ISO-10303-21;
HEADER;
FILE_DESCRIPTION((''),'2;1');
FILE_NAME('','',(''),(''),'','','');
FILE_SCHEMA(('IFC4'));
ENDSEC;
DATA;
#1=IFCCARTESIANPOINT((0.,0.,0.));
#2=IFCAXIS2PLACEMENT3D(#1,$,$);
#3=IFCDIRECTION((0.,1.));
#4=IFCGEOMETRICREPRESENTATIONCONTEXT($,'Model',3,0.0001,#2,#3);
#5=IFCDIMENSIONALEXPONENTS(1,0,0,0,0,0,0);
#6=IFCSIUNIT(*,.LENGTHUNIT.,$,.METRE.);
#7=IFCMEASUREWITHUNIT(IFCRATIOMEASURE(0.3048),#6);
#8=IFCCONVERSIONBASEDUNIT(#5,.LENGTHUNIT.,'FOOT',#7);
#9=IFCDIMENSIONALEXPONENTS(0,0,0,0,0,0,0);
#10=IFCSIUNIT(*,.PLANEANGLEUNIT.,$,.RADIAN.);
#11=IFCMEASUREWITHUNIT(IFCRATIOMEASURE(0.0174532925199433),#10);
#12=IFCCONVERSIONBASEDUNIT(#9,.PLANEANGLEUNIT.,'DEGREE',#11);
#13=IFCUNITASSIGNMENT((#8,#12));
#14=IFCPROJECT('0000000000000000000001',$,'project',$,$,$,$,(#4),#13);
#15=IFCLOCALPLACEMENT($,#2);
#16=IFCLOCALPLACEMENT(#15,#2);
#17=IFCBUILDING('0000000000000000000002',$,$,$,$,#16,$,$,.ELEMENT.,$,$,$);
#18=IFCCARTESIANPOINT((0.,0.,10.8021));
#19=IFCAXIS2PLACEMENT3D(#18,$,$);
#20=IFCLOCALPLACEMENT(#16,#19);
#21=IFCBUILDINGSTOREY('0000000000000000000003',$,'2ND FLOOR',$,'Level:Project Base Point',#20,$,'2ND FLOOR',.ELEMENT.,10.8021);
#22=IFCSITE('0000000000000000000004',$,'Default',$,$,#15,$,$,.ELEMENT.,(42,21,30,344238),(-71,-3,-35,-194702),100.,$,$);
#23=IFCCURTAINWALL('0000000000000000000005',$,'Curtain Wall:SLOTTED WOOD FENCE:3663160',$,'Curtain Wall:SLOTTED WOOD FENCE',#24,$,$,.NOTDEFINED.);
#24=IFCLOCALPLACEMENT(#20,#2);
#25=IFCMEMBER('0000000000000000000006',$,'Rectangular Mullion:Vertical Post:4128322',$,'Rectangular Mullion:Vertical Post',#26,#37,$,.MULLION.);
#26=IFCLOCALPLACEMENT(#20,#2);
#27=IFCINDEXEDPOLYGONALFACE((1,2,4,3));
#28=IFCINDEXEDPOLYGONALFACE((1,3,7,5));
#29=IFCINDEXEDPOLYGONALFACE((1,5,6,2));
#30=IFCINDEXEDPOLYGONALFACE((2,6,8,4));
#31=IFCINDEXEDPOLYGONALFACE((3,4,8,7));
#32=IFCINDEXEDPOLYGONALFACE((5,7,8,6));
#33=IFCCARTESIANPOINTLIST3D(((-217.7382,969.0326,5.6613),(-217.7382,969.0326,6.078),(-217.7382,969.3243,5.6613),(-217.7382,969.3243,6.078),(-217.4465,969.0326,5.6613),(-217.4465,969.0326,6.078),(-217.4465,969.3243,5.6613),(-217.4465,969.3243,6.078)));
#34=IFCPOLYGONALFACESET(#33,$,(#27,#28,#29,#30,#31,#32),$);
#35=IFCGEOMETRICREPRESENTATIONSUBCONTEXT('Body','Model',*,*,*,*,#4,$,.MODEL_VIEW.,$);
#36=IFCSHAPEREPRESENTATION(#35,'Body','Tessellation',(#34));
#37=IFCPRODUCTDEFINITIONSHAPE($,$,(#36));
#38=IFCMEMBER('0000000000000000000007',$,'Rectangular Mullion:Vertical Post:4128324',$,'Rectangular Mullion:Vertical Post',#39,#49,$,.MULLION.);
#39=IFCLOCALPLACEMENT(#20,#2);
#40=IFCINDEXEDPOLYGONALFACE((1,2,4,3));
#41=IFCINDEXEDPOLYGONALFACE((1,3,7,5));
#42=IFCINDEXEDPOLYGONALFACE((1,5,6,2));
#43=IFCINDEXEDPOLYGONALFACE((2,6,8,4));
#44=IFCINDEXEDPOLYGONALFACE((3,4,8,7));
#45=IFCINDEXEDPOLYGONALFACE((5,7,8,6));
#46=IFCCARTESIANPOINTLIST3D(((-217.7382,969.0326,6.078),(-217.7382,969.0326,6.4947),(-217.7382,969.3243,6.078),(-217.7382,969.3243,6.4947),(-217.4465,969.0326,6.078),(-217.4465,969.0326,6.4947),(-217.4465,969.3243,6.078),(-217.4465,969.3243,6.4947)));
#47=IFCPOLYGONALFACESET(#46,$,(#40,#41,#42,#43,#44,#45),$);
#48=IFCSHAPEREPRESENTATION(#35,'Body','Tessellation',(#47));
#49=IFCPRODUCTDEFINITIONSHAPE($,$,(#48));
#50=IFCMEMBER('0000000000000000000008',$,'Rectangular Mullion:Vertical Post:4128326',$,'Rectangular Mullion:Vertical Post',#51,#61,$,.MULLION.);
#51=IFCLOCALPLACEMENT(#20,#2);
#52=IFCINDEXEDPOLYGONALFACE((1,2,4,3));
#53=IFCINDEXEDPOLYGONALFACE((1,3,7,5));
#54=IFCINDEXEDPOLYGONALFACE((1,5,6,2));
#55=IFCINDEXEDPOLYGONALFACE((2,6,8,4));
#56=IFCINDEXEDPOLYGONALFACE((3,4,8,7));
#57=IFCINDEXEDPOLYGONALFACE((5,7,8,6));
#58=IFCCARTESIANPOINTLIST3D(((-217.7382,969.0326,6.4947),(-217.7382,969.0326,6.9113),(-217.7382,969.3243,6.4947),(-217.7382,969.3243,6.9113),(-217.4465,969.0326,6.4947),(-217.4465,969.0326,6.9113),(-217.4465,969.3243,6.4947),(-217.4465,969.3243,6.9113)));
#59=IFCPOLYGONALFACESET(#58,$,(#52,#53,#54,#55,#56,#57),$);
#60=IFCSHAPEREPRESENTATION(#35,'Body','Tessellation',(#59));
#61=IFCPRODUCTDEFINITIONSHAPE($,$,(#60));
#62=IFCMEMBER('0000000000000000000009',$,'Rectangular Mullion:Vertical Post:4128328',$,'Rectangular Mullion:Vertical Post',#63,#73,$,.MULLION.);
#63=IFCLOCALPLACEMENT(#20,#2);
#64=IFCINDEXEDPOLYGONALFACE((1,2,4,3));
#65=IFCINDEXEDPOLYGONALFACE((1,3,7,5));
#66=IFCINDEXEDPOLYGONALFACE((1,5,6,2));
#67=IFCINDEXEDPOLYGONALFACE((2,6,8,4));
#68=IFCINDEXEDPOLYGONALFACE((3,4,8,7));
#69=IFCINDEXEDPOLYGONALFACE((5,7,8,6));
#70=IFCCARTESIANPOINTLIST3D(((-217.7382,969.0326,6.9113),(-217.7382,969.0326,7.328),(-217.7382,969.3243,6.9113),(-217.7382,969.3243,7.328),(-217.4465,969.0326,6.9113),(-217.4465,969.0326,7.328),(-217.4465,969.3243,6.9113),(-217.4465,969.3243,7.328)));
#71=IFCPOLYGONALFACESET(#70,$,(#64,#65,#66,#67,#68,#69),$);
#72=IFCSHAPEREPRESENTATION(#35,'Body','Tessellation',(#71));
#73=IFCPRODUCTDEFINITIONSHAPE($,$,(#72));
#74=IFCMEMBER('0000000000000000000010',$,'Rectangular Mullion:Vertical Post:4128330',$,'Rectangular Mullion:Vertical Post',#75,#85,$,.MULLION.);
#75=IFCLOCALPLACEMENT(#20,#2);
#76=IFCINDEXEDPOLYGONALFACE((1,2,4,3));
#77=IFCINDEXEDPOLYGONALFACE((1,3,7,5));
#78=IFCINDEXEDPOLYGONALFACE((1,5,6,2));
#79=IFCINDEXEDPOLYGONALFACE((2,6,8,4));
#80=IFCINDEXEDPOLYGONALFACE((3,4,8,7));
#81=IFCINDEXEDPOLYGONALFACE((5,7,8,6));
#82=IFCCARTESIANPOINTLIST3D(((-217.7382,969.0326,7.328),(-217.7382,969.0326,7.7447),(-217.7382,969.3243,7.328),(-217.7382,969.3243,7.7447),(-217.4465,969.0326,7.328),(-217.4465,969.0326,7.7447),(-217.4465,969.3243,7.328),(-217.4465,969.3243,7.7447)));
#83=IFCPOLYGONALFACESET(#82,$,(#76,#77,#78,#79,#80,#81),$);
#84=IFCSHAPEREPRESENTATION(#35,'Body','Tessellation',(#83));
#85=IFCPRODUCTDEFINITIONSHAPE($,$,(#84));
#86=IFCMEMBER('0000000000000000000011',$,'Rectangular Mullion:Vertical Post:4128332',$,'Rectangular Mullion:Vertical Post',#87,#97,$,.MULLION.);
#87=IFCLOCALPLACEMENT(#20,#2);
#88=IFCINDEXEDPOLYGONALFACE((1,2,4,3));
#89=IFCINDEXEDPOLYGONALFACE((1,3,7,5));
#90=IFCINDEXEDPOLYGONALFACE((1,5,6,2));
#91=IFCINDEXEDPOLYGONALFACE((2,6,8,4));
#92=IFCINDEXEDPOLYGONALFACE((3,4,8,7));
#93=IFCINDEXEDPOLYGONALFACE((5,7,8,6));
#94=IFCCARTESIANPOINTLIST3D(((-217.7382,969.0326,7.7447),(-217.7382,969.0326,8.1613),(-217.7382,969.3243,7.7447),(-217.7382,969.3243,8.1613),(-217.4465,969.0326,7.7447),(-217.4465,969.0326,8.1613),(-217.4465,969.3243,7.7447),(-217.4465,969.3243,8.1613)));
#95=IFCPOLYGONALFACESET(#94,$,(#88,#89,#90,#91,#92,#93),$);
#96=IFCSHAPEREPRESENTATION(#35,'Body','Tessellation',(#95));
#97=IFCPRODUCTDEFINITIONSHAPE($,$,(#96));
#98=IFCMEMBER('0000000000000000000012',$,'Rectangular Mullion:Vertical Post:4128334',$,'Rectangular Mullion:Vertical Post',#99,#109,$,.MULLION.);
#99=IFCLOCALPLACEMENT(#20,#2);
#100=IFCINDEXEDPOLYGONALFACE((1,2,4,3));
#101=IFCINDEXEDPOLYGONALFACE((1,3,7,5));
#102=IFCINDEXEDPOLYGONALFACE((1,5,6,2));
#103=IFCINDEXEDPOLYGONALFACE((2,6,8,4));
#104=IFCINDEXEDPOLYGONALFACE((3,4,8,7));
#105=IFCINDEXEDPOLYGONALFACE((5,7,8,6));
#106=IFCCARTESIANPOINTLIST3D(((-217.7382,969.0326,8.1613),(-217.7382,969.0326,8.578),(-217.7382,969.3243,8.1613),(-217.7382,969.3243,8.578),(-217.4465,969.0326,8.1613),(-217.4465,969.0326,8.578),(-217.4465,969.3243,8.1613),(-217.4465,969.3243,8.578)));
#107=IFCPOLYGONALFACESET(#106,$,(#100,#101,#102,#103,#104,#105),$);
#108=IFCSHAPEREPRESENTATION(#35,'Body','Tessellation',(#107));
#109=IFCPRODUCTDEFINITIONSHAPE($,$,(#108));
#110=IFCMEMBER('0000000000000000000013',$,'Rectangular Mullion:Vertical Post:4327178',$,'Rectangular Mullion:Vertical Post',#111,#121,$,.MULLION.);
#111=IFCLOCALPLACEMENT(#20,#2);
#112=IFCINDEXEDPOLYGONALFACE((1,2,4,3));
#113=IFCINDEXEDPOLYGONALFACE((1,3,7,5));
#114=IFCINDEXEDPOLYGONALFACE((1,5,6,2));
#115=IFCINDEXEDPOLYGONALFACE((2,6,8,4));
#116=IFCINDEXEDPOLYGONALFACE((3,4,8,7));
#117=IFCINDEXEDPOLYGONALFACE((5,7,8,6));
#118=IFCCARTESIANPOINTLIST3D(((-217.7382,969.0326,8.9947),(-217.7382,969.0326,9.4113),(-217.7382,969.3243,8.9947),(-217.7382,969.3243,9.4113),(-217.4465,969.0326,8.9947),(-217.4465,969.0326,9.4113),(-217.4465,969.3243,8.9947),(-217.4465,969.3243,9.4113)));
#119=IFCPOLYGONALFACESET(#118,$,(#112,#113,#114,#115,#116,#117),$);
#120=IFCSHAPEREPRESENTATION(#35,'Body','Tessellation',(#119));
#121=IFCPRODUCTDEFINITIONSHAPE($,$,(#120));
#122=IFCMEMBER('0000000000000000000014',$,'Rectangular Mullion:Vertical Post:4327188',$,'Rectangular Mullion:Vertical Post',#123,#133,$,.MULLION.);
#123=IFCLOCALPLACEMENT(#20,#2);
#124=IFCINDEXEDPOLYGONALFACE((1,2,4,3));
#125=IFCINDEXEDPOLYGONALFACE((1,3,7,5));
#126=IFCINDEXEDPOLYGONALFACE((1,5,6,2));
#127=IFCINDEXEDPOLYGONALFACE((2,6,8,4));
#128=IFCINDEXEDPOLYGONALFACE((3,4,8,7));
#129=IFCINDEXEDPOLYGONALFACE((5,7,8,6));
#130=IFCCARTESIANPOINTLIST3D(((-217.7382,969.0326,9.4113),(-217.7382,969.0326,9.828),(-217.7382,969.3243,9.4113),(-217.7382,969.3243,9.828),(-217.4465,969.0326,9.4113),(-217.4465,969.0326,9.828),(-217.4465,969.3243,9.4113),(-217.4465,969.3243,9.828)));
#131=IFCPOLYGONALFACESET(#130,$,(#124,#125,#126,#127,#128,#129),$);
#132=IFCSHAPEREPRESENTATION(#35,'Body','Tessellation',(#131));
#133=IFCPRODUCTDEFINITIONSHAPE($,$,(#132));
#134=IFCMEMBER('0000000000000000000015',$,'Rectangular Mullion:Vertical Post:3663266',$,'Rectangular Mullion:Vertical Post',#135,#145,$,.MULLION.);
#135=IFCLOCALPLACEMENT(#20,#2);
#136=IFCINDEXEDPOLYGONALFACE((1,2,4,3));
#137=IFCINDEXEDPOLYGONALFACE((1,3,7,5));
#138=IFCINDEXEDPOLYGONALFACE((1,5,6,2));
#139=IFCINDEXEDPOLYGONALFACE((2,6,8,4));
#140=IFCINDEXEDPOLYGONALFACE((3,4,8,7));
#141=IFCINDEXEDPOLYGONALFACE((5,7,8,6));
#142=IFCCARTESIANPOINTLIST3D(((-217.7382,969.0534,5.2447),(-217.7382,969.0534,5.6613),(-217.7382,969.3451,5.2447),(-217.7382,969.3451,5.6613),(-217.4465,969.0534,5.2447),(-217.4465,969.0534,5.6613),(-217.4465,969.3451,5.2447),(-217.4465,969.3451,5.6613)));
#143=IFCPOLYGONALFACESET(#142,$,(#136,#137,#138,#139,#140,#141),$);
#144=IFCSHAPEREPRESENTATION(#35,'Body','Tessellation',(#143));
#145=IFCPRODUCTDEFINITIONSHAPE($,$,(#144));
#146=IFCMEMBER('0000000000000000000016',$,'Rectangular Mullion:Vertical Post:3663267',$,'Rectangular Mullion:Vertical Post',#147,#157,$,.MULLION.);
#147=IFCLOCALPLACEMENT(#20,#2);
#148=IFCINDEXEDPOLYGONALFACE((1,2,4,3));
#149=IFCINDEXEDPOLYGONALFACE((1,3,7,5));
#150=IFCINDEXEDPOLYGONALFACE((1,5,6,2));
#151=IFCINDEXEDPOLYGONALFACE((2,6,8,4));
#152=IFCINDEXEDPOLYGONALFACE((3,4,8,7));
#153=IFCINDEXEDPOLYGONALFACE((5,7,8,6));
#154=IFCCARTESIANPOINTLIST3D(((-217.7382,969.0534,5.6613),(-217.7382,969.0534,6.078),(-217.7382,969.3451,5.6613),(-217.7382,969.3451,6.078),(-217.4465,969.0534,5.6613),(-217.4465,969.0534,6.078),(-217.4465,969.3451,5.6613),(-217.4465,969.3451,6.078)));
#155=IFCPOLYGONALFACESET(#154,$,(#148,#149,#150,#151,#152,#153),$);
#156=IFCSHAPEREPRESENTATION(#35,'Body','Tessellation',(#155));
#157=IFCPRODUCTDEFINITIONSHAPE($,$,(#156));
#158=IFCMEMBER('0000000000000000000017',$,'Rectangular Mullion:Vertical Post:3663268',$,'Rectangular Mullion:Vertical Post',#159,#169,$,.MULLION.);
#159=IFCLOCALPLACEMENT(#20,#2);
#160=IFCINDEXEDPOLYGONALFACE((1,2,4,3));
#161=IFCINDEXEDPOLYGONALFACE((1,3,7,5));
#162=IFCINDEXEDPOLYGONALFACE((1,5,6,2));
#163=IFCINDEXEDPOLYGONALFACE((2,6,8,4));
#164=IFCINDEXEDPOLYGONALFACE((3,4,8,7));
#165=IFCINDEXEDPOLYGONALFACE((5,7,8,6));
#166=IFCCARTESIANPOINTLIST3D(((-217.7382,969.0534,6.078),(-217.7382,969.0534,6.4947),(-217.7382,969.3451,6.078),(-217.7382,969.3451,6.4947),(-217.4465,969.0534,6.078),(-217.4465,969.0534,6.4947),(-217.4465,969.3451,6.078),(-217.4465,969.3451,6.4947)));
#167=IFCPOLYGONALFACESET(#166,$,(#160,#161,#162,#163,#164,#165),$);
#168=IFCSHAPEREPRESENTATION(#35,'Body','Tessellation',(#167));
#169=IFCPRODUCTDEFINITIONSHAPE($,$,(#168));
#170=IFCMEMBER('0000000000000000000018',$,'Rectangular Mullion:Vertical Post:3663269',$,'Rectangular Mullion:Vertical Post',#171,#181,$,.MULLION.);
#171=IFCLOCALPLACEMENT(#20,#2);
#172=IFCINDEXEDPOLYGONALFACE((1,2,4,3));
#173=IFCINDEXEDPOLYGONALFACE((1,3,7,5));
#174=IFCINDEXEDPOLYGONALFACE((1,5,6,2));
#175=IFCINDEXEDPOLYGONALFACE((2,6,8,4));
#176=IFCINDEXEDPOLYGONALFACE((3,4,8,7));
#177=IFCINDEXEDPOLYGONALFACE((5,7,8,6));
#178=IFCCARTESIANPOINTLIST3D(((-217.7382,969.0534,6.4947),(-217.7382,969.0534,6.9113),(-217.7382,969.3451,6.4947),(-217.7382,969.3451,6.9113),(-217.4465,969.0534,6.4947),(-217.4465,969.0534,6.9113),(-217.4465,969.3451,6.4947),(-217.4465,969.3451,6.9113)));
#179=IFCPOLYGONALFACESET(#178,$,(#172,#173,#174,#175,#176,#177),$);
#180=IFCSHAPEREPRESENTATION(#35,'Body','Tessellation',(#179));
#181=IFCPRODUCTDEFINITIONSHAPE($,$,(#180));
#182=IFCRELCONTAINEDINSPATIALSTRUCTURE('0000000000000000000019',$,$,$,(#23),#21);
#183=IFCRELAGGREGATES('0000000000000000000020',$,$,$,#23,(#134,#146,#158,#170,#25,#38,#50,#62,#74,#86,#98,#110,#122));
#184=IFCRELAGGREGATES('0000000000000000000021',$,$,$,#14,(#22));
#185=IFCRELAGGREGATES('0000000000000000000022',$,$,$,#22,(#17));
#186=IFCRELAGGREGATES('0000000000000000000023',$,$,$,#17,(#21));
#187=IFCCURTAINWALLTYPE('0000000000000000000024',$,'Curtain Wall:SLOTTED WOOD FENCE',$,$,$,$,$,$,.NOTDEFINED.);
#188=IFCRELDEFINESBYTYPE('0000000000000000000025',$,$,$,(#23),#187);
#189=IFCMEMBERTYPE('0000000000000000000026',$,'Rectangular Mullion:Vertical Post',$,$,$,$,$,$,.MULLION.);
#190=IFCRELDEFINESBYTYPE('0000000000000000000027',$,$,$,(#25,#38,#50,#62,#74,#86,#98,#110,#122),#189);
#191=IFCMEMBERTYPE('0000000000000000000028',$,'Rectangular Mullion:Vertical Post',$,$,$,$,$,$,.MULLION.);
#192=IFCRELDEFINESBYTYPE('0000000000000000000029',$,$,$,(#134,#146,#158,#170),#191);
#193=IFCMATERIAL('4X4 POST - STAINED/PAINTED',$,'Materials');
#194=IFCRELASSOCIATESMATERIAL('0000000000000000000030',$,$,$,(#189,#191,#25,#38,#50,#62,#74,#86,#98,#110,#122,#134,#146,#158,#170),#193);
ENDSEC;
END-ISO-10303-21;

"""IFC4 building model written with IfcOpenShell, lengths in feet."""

from ifc_helpers import new_model, entity, si_unit, converted_unit, direction, frame, origin, origin_2d_with_axis, place, context, subcontext, project, spatial, rectangle, extrude, source, transform, mapped, material, material_profile, profile_set, profile_usage, type_object, type_shapes, element, aggregate, save


model = new_model("IFC4")

# Units and contexts
model_context = context("Model", 3, precision=0.0001, world=origin(), true_north=direction((0.0, 1.0)))
body_context = subcontext(model_context, "Body", "Model", "MODEL_VIEW")
ifc_project = project(units=[converted_unit("LENGTHUNIT", "FOOT", entity("IfcRatioMeasure", 0.3048), si_unit("LENGTHUNIT", "METRE"), dimensions=[1, 0, 0, 0, 0, 0, 0]), converted_unit("PLANEANGLEUNIT", "DEGREE", entity("IfcRatioMeasure", 0.0174532925199433), si_unit("PLANEANGLEUNIT", "RADIAN"), dimensions=[0, 0, 0, 0, 0, 0, 0])], contexts=[model_context])

# Site, building, storey
site_placement = place(None, origin())
site = spatial("IfcSite", under=ifc_project, at=site_placement, Name="Default", CompositionType="ELEMENT", RefLatitude=(42, 21, 30, 344238), RefLongitude=(-71, -3, -35, -194702), RefElevation=100.0)
building_placement = place(site_placement, origin())
building = spatial("IfcBuilding", under=site, at=building_placement, CompositionType="ELEMENT")
storey_placement = place(building_placement, frame((0.0, 0.0, 10.8021)))
storey = spatial("IfcBuildingStorey", under=building, at=storey_placement, Name="2ND FLOOR", ObjectType="Level:Project Base Point", LongName="2ND FLOOR", CompositionType="ELEMENT", Elevation=10.8021)

# Curtain wall, members
curtain_wall_type = type_object("IfcCurtainWallType", Name="Curtain Wall:SLOTTED WOOD FENCE", PredefinedType="NOTDEFINED")
curtain_wall_placement = place(storey_placement, frame((0.0, 0.0, -10.8021)))
curtain_wall = element("IfcCurtainWall", 1, at=curtain_wall_placement, inside=storey, type_object=curtain_wall_type, Name="Curtain Wall:SLOTTED WOOD FENCE:3663160", ObjectType="Curtain Wall:SLOTTED WOOD FENCE", PredefinedType="NOTDEFINED")
ifc_material_1 = material(Name="4X4 POST - STAINED/PAINTED", Category="Materials")
ifc_material_profile = material_profile(ifc_material_1, rectangle(XDim=0.2917, YDim=0.2917, at=origin_2d_with_axis()), Name="Vertical Post")
ifc_profile_set = profile_set([ifc_material_profile], Name="Vertical Post")
ifc_profile_usage_1 = profile_usage(ifc_profile_set)
member_type_1 = type_object("IfcMemberType", Name="Rectangular Mullion:Vertical Post", PredefinedType="MULLION", material=ifc_profile_set)
shared_shape_1 = source(origin(), body_context, "Body", "SweptSolid", [
    extrude(rectangle(XDim=0.2917, YDim=0.2917, at=origin_2d_with_axis()), frame((0.0, -0.2083, -0.4167), z_axis=(0.0, 0.0, 1.0), x_axis=(0.0, -1.0, 0.0)), (0.0, 0.0, 1.0), 0.4167),
])
type_shapes(member_type_1, [shared_shape_1])
member_1_placement = place(storey_placement, frame((-217.8007, 969.1784, 5.6613), z_axis=(0.0, 0.0, -1.0), x_axis=(0.0, -1.0, 0.0)))
member_1 = element("IfcMember", 2, at=member_1_placement, type_object=member_type_1, material=ifc_profile_usage_1, Name="Rectangular Mullion:Vertical Post:4128322", ObjectType="Rectangular Mullion:Vertical Post", PredefinedType="MULLION", context=body_context, shape_type="MappedRepresentation", body=[
    mapped(shared_shape_1, transform((0.0, 0.0, 0.0), scale=1.0)),
])
ifc_profile_usage_2 = profile_usage(ifc_profile_set)
member_2_placement = place(storey_placement, frame((-217.8007, 969.1784, 6.078), z_axis=(0.0, 0.0, -1.0), x_axis=(0.0, -1.0, 0.0)))
member_2 = element("IfcMember", 3, at=member_2_placement, type_object=member_type_1, material=ifc_profile_usage_2, Name="Rectangular Mullion:Vertical Post:4128324", ObjectType="Rectangular Mullion:Vertical Post", PredefinedType="MULLION", context=body_context, shape_type="MappedRepresentation", body=[
    mapped(shared_shape_1, transform((0.0, 0.0, 0.0), scale=1.0)),
])
ifc_profile_usage_3 = profile_usage(ifc_profile_set)
member_3_placement = place(storey_placement, frame((-217.8007, 969.1784, 6.4947), z_axis=(0.0, 0.0, -1.0), x_axis=(0.0, -1.0, 0.0)))
member_3 = element("IfcMember", 4, at=member_3_placement, type_object=member_type_1, material=ifc_profile_usage_3, Name="Rectangular Mullion:Vertical Post:4128326", ObjectType="Rectangular Mullion:Vertical Post", PredefinedType="MULLION", context=body_context, shape_type="MappedRepresentation", body=[
    mapped(shared_shape_1, transform((0.0, 0.0, 0.0), scale=1.0)),
])
ifc_profile_usage_4 = profile_usage(ifc_profile_set)
member_4_placement = place(storey_placement, frame((-217.8007, 969.1784, 6.9113), z_axis=(0.0, 0.0, -1.0), x_axis=(0.0, -1.0, 0.0)))
member_4 = element("IfcMember", 5, at=member_4_placement, type_object=member_type_1, material=ifc_profile_usage_4, Name="Rectangular Mullion:Vertical Post:4128328", ObjectType="Rectangular Mullion:Vertical Post", PredefinedType="MULLION", context=body_context, shape_type="MappedRepresentation", body=[
    mapped(shared_shape_1, transform((0.0, 0.0, 0.0), scale=1.0)),
])
ifc_profile_usage_5 = profile_usage(ifc_profile_set)
member_5_placement = place(storey_placement, frame((-217.8007, 969.1784, 7.328), z_axis=(0.0, 0.0, -1.0), x_axis=(0.0, -1.0, 0.0)))
member_5 = element("IfcMember", 6, at=member_5_placement, type_object=member_type_1, material=ifc_profile_usage_5, Name="Rectangular Mullion:Vertical Post:4128330", ObjectType="Rectangular Mullion:Vertical Post", PredefinedType="MULLION", context=body_context, shape_type="MappedRepresentation", body=[
    mapped(shared_shape_1, transform((0.0, 0.0, 0.0), scale=1.0)),
])
ifc_profile_usage_6 = profile_usage(ifc_profile_set)
member_6_placement = place(storey_placement, frame((-217.8007, 969.1784, 7.7447), z_axis=(0.0, 0.0, -1.0), x_axis=(0.0, -1.0, 0.0)))
member_6 = element("IfcMember", 7, at=member_6_placement, type_object=member_type_1, material=ifc_profile_usage_6, Name="Rectangular Mullion:Vertical Post:4128332", ObjectType="Rectangular Mullion:Vertical Post", PredefinedType="MULLION", context=body_context, shape_type="MappedRepresentation", body=[
    mapped(shared_shape_1, transform((0.0, 0.0, 0.0), scale=1.0)),
])
ifc_profile_usage_7 = profile_usage(ifc_profile_set)
member_7_placement = place(storey_placement, frame((-217.8007, 969.1784, 8.1613), z_axis=(0.0, 0.0, -1.0), x_axis=(0.0, -1.0, 0.0)))
member_7 = element("IfcMember", 8, at=member_7_placement, type_object=member_type_1, material=ifc_profile_usage_7, Name="Rectangular Mullion:Vertical Post:4128334", ObjectType="Rectangular Mullion:Vertical Post", PredefinedType="MULLION", context=body_context, shape_type="MappedRepresentation", body=[
    mapped(shared_shape_1, transform((0.0, 0.0, 0.0), scale=1.0)),
])
ifc_profile_usage_8 = profile_usage(ifc_profile_set)
member_8_placement = place(storey_placement, frame((-217.8007, 969.1784, 8.9947), z_axis=(0.0, 0.0, -1.0), x_axis=(0.0, -1.0, 0.0)))
member_8 = element("IfcMember", 9, at=member_8_placement, type_object=member_type_1, material=ifc_profile_usage_8, Name="Rectangular Mullion:Vertical Post:4327178", ObjectType="Rectangular Mullion:Vertical Post", PredefinedType="MULLION", context=body_context, shape_type="MappedRepresentation", body=[
    mapped(shared_shape_1, transform((0.0, 0.0, 0.0), scale=1.0)),
])
ifc_profile_usage_9 = profile_usage(ifc_profile_set)
member_9_placement = place(storey_placement, frame((-217.8007, 969.1784, 9.4113), z_axis=(0.0, 0.0, -1.0), x_axis=(0.0, -1.0, 0.0)))
member_9 = element("IfcMember", 10, at=member_9_placement, type_object=member_type_1, material=ifc_profile_usage_9, Name="Rectangular Mullion:Vertical Post:4327188", ObjectType="Rectangular Mullion:Vertical Post", PredefinedType="MULLION", context=body_context, shape_type="MappedRepresentation", body=[
    mapped(shared_shape_1, transform((0.0, 0.0, 0.0), scale=1.0)),
])
ifc_profile_usage_10 = profile_usage(ifc_profile_set)
member_type_2 = type_object("IfcMemberType", Name="Rectangular Mullion:Vertical Post", PredefinedType="MULLION", material=ifc_profile_set)
shared_shape_2 = source(origin(), body_context, "Body", "SweptSolid", [
    extrude(rectangle(XDim=0.2917, YDim=0.2917, at=origin_2d_with_axis()), frame((-0.1458, -0.2083, -0.4167), z_axis=(0.0, 0.0, 1.0), x_axis=(0.0, -1.0, 0.0)), (0.0, 0.0, 1.0), 0.4167),
])
type_shapes(member_type_2, [shared_shape_2])
member_10_placement = place(storey_placement, frame((-217.8007, 969.3451, 5.6613), z_axis=(0.0, 0.0, 1.0), x_axis=(0.0, 1.0, 0.0)))
member_10 = element("IfcMember", 11, at=member_10_placement, type_object=member_type_2, material=ifc_profile_usage_10, Name="Rectangular Mullion:Vertical Post:3663266", ObjectType="Rectangular Mullion:Vertical Post", PredefinedType="MULLION", context=body_context, shape_type="MappedRepresentation", body=[
    mapped(shared_shape_2, transform((0.0, 0.0, 0.0), scale=1.0)),
])
ifc_profile_usage_11 = profile_usage(ifc_profile_set)
member_11_placement = place(storey_placement, frame((-217.8007, 969.3451, 6.078), z_axis=(0.0, 0.0, 1.0), x_axis=(0.0, 1.0, 0.0)))
member_11 = element("IfcMember", 12, at=member_11_placement, type_object=member_type_2, material=ifc_profile_usage_11, Name="Rectangular Mullion:Vertical Post:3663267", ObjectType="Rectangular Mullion:Vertical Post", PredefinedType="MULLION", context=body_context, shape_type="MappedRepresentation", body=[
    mapped(shared_shape_2, transform((0.0, 0.0, 0.0), scale=1.0)),
])
ifc_profile_usage_12 = profile_usage(ifc_profile_set)
member_12_placement = place(storey_placement, frame((-217.8007, 969.3451, 6.4947), z_axis=(0.0, 0.0, 1.0), x_axis=(0.0, 1.0, 0.0)))
member_12 = element("IfcMember", 13, at=member_12_placement, type_object=member_type_2, material=ifc_profile_usage_12, Name="Rectangular Mullion:Vertical Post:3663268", ObjectType="Rectangular Mullion:Vertical Post", PredefinedType="MULLION", context=body_context, shape_type="MappedRepresentation", body=[
    mapped(shared_shape_2, transform((0.0, 0.0, 0.0), scale=1.0)),
])
ifc_profile_usage_13 = profile_usage(ifc_profile_set)
member_13_placement = place(storey_placement, frame((-217.8007, 969.3451, 6.9113), z_axis=(0.0, 0.0, 1.0), x_axis=(0.0, 1.0, 0.0)))
member_13 = element("IfcMember", 14, at=member_13_placement, type_object=member_type_2, material=ifc_profile_usage_13, Name="Rectangular Mullion:Vertical Post:3663269", ObjectType="Rectangular Mullion:Vertical Post", PredefinedType="MULLION", context=body_context, shape_type="MappedRepresentation", body=[
    mapped(shared_shape_2, transform((0.0, 0.0, 0.0), scale=1.0)),
])
aggregate(curtain_wall, [member_10, member_11, member_12, member_13, member_1, member_2, member_3, member_4, member_5, member_6, member_7, member_8, member_9])

save(model, "model.ifc")
